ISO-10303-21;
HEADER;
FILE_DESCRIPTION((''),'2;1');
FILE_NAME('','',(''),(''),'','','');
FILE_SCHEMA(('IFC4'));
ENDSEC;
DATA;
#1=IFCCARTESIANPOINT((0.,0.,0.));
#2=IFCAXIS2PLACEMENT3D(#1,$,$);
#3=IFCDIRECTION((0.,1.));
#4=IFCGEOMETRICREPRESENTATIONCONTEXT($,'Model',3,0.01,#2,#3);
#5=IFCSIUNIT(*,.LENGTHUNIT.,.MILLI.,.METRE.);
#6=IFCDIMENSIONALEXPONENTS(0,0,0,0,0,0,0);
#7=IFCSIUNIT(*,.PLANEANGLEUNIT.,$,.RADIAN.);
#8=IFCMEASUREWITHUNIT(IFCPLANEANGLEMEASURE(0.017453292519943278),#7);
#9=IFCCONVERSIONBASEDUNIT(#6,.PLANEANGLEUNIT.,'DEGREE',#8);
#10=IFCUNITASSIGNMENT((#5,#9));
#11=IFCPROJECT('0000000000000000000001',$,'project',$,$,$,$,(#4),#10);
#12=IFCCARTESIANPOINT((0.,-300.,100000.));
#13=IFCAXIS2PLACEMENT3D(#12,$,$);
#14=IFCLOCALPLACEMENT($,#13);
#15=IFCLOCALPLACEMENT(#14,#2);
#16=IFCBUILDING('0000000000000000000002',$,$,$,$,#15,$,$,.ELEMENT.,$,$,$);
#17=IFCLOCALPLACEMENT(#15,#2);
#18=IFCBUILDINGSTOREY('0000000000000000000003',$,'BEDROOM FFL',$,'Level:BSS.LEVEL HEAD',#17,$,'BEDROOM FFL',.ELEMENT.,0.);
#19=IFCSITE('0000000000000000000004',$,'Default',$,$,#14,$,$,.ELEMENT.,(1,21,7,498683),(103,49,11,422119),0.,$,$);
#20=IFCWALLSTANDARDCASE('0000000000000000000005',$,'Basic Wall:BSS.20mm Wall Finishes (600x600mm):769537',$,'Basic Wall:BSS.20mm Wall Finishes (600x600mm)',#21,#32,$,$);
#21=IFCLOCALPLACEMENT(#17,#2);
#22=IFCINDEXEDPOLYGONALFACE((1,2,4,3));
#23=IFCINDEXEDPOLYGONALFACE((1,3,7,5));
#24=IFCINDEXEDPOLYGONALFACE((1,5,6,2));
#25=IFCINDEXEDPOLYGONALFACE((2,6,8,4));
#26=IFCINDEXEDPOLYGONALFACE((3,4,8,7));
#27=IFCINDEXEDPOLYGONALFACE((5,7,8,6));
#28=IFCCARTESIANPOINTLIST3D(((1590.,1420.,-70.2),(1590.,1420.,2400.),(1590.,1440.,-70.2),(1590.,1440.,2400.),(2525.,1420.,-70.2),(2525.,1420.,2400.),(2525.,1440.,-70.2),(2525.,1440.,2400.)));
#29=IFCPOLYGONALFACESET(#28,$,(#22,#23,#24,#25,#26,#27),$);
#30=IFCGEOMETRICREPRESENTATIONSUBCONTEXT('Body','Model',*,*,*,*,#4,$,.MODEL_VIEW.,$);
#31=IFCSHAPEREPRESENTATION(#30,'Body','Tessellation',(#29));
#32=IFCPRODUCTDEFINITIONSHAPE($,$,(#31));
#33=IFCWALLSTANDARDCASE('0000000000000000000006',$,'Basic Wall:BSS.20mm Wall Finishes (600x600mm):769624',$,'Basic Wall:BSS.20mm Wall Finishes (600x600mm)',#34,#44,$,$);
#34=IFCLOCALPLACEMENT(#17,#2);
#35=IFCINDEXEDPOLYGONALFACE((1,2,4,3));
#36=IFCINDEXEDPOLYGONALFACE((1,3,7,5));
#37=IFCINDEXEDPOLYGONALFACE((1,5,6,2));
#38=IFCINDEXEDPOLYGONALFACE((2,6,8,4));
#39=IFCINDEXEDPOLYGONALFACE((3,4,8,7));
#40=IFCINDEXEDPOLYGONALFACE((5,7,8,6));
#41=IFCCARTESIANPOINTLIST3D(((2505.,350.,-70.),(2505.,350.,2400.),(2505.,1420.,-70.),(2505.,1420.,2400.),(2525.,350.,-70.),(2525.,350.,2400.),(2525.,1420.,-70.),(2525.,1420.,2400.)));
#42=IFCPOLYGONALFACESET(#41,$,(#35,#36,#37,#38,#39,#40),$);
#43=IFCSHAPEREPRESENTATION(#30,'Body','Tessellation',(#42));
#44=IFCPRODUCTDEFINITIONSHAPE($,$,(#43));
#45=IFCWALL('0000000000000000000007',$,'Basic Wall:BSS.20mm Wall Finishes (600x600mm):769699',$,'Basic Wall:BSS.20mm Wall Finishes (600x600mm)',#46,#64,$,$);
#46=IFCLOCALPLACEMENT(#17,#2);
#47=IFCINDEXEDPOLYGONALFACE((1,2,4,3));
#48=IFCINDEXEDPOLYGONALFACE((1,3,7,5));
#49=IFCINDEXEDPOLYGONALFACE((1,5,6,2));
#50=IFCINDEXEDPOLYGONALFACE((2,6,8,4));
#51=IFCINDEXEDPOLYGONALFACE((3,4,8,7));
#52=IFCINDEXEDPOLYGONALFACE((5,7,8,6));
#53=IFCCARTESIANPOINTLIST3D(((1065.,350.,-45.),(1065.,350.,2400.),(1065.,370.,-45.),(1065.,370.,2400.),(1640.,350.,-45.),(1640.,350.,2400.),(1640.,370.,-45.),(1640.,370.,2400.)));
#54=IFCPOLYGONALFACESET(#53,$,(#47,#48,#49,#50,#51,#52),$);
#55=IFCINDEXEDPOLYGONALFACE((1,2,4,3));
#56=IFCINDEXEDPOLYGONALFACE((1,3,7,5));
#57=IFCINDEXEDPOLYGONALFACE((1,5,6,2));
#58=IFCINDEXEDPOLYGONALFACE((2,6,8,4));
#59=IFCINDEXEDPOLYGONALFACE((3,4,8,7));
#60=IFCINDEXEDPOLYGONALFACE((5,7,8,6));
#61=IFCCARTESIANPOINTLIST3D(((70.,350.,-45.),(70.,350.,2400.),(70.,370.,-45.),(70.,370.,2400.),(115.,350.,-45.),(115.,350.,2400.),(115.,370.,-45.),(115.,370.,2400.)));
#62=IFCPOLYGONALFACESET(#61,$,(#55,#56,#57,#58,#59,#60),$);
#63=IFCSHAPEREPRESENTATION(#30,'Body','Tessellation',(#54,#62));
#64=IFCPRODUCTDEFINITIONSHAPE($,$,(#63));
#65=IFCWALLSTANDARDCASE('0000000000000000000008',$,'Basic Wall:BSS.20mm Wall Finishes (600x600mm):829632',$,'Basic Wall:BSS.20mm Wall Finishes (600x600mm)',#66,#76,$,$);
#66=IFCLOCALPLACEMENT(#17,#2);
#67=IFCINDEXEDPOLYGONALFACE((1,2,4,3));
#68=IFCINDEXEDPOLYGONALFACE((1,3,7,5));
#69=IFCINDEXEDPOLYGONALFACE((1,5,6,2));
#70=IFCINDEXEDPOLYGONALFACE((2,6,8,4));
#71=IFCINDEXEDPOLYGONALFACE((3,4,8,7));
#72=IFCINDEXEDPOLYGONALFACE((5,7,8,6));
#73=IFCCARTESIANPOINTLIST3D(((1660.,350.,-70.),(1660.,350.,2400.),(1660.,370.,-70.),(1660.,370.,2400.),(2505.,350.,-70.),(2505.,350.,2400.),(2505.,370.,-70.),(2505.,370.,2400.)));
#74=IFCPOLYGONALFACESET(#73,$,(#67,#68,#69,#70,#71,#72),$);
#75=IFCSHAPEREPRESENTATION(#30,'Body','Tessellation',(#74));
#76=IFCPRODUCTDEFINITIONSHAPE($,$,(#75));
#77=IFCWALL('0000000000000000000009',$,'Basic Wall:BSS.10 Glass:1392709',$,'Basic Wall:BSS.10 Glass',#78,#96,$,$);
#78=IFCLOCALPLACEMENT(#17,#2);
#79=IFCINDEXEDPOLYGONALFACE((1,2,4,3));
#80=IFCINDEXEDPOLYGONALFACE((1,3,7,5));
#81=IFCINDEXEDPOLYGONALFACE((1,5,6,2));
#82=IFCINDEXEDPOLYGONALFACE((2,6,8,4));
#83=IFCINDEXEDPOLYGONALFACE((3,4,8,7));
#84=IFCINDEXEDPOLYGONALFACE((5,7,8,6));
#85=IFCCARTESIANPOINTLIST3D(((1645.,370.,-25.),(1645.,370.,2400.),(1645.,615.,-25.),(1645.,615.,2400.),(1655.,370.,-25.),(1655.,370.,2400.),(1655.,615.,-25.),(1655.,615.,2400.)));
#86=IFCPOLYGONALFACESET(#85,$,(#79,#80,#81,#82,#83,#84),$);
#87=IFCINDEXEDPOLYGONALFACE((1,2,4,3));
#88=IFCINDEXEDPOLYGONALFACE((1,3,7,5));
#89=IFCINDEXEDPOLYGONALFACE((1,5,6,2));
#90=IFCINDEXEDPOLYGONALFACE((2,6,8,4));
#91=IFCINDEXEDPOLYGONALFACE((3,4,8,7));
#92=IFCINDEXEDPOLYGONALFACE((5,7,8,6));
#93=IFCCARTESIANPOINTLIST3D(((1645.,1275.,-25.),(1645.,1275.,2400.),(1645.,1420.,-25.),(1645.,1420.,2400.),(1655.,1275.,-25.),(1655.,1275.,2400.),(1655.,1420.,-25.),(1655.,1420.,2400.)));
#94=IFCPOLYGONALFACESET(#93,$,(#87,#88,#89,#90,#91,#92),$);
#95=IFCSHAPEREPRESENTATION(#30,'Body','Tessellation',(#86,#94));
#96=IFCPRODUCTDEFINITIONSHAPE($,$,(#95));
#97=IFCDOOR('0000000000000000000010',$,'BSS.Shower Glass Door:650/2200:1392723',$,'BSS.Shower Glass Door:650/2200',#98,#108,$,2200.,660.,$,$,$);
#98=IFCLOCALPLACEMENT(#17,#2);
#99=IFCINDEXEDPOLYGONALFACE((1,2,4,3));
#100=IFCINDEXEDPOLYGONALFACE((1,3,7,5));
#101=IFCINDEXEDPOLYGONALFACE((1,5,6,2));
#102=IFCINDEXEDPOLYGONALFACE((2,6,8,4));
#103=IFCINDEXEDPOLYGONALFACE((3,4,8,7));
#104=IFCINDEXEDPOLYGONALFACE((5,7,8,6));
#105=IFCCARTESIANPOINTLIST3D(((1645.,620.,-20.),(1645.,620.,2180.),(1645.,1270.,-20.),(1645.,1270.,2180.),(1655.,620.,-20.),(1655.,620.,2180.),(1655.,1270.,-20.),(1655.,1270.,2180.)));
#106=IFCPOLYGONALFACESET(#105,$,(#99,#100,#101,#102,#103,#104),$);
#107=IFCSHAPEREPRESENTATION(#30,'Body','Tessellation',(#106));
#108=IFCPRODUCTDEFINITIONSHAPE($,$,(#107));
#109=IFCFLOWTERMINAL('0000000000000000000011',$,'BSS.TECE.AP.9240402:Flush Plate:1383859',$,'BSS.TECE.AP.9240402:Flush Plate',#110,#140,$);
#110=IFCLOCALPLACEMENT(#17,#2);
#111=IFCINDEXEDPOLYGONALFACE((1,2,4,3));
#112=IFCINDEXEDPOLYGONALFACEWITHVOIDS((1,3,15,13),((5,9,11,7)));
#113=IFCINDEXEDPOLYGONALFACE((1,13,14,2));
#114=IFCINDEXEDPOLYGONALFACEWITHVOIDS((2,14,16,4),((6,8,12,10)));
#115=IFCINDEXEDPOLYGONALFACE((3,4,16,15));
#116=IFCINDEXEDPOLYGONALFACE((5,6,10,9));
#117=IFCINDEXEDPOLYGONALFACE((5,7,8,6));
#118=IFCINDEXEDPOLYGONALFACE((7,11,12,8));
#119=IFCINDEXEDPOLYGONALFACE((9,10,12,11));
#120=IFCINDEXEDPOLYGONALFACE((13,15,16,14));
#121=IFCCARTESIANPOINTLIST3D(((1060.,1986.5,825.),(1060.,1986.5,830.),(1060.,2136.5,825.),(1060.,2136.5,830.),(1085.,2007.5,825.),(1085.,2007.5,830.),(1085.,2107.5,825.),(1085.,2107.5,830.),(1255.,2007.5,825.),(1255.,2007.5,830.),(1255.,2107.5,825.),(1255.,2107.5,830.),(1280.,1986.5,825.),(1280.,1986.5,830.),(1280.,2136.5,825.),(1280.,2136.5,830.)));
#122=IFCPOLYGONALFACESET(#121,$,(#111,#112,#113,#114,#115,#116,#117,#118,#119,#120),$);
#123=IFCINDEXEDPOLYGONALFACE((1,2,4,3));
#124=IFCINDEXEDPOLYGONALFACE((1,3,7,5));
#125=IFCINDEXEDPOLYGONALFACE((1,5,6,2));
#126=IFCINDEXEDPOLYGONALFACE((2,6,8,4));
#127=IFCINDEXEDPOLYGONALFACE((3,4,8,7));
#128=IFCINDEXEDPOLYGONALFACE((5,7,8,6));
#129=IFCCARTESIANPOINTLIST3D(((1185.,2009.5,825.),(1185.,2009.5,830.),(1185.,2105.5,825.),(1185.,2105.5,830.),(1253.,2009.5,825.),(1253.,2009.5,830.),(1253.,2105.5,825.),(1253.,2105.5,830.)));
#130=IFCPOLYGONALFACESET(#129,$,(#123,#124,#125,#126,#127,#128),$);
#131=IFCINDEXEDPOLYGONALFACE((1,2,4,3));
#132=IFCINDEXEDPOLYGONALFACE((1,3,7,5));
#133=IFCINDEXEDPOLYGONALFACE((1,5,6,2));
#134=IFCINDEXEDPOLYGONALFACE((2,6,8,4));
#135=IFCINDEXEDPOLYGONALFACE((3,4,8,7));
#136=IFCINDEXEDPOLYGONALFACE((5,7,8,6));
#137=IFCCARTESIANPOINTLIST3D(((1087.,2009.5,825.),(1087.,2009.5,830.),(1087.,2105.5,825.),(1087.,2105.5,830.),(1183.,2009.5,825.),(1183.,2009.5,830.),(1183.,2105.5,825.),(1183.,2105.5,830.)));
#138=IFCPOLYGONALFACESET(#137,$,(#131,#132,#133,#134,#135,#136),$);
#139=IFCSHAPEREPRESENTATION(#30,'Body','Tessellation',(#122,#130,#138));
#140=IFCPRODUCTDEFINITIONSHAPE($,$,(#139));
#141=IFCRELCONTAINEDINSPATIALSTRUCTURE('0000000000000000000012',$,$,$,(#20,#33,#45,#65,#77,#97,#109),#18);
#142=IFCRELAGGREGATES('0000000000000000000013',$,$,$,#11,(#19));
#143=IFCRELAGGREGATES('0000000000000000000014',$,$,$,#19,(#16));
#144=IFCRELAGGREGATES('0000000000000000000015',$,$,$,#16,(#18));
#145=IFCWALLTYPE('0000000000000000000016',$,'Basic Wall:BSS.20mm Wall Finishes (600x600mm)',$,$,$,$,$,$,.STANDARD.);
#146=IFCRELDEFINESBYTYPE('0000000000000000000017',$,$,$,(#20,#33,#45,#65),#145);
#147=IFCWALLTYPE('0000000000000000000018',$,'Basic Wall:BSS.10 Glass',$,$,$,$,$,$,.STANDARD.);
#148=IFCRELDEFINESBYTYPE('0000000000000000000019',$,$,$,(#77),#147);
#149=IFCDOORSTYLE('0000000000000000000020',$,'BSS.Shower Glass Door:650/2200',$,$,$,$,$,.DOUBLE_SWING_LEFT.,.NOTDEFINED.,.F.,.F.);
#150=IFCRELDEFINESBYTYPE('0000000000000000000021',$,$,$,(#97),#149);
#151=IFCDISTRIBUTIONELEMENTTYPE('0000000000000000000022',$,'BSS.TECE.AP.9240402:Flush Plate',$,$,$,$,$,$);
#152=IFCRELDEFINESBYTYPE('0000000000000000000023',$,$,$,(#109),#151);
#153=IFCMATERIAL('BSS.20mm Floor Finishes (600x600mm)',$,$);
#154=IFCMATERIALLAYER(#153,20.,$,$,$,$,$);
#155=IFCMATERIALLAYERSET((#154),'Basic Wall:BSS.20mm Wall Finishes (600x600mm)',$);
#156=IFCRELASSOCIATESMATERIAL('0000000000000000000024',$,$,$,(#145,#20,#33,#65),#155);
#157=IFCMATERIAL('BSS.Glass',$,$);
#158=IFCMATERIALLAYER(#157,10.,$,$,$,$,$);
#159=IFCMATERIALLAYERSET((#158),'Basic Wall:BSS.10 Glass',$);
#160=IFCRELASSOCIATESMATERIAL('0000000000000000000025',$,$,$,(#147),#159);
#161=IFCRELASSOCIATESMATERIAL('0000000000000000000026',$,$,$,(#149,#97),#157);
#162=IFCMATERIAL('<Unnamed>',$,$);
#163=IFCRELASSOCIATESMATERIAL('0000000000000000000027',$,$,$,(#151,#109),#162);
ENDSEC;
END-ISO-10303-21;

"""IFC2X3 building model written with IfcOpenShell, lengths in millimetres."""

from ifc_helpers import new_model, entity, si_unit, converted_unit, direction, frame, frame_2d, origin, origin_2d_with_axis, place, context, subcontext, project, spatial, polyline, rectangle, outline, extrude, source, transform, mapped, material, layer, layer_set, layer_usage, type_object, type_shapes, element, fill, save


model = new_model("IFC2X3")

# Units and contexts
model_context = context("Model", 3, precision=0.01, world=origin(), true_north=direction((0.0, 1.0)))
body_context = subcontext(model_context, "Body", "Model", "MODEL_VIEW")
ifc_project = project(units=[si_unit("LENGTHUNIT", "METRE", prefix="MILLI"), converted_unit("PLANEANGLEUNIT", "DEGREE", entity("IfcPlaneAngleMeasure", 0.017453292519943278), si_unit("PLANEANGLEUNIT", "RADIAN"), dimensions=[0, 0, 0, 0, 0, 0, 0])], contexts=[model_context])

# Site, building, storey
site_placement = place(None, frame((0.0, -300.0, 100000.0)))
site = spatial("IfcSite", under=ifc_project, at=site_placement, Name="Default", CompositionType="ELEMENT", RefLatitude=(1, 21, 7, 498683), RefLongitude=(103, 49, 11, 422119), RefElevation=0.0)
building_placement = place(site_placement, origin())
building = spatial("IfcBuilding", under=site, at=building_placement, CompositionType="ELEMENT")
storey_placement = place(building_placement, origin())
storey = spatial("IfcBuildingStorey", under=building, at=storey_placement, Name="BEDROOM FFL", ObjectType="Level:BSS.LEVEL HEAD", LongName="BEDROOM FFL", CompositionType="ELEMENT", Elevation=0.0)

# Shared definitions
ifc_material_1 = material(Name="BSS.20mm Floor Finishes (600x600mm)")

# Shared definitions
ifc_layer_1 = layer(ifc_material_1, 20.0)
ifc_layer_set_1 = layer_set([ifc_layer_1], Name="Basic Wall:BSS.20mm Wall Finishes (600x600mm)")
wall_type_1 = type_object("IfcWallType", Name="Basic Wall:BSS.20mm Wall Finishes (600x600mm)", PredefinedType="STANDARD", material=ifc_layer_set_1)

# Walls
ifc_layer_usage_1 = layer_usage(ifc_layer_set_1, "AXIS2", "NEGATIVE", 10.0)
wall_1_placement = place(storey_placement, frame((1590.0, 1430.0, -70.2)))
element("IfcWallStandardCase", 1, at=wall_1_placement, inside=storey, type_object=wall_type_1, material=ifc_layer_usage_1, Name="Basic Wall:BSS.20mm Wall Finishes (600x600mm):769537", ObjectType="Basic Wall:BSS.20mm Wall Finishes (600x600mm)", context=body_context, shape_type="SweptSolid", body=[
    extrude(rectangle(XDim=935.0, YDim=20.0, at=frame_2d((467.5, 0.0), x_axis=(-1.0, 0.0))), origin(), (0.0, 0.0, 1.0), 2470.2),
])
ifc_layer_usage_2 = layer_usage(ifc_layer_set_1, "AXIS2", "NEGATIVE", 10.0)
wall_2_placement = place(storey_placement, frame((2515.0, 1420.0, -70.0), z_axis=(0.0, 0.0, 1.0), x_axis=(0.0, -1.0, 0.0)))
element("IfcWallStandardCase", 2, at=wall_2_placement, inside=storey, type_object=wall_type_1, material=ifc_layer_usage_2, Name="Basic Wall:BSS.20mm Wall Finishes (600x600mm):769624", ObjectType="Basic Wall:BSS.20mm Wall Finishes (600x600mm)", context=body_context, shape_type="SweptSolid", body=[
    extrude(rectangle(XDim=1070.0, YDim=20.0, at=frame_2d((535.0, 0.0), x_axis=(-1.0, 0.0))), origin(), (0.0, 0.0, 1.0), 2470.0),
])
wall_3_placement = place(storey_placement, frame((1640.0, 360.0, -45.0), z_axis=(0.0, 0.0, 1.0), x_axis=(-1.0, 0.0, 0.0)))
element("IfcWall", 3, at=wall_3_placement, inside=storey, type_object=wall_type_1, Name="Basic Wall:BSS.20mm Wall Finishes (600x600mm):769699", ObjectType="Basic Wall:BSS.20mm Wall Finishes (600x600mm)", context=body_context, shape_type="SweptSolid", body=[
    extrude(rectangle(XDim=575.0, YDim=20.0, at=frame_2d((0.0, 0.0), x_axis=(1.0, 0.0))), frame((287.5, 0.0, 0.0)), (0.0, 0.0, 1.0), 2445.0),
    extrude(rectangle(XDim=45.0, YDim=20.0, at=frame_2d((0.0, 0.0), x_axis=(1.0, 0.0))), frame((1547.5, 0.0, 0.0), z_axis=(0.0, 0.0, 1.0), x_axis=(-1.0, 0.0, 0.0)), (0.0, 0.0, 1.0), 2445.0),
])
ifc_layer_usage_3 = layer_usage(ifc_layer_set_1, "AXIS2", "NEGATIVE", 10.0)
wall_4_placement = place(storey_placement, frame((1660.0, 360.0, -70.0)))
element("IfcWallStandardCase", 4, at=wall_4_placement, inside=storey, type_object=wall_type_1, material=ifc_layer_usage_3, Name="Basic Wall:BSS.20mm Wall Finishes (600x600mm):829632", ObjectType="Basic Wall:BSS.20mm Wall Finishes (600x600mm)", context=body_context, shape_type="SweptSolid", body=[
    extrude(rectangle(XDim=845.0, YDim=20.0, at=frame_2d((422.5, 0.0), x_axis=(-1.0, 0.0))), origin(), (0.0, 0.0, 1.0), 2470.0),
])

# Wall, opening, door
ifc_material_2 = material(Name="BSS.Glass")
ifc_layer_2 = layer(ifc_material_2, 10.0)
ifc_layer_set_2 = layer_set([ifc_layer_2], Name="Basic Wall:BSS.10 Glass")
wall_type_2 = type_object("IfcWallType", Name="Basic Wall:BSS.10 Glass", PredefinedType="STANDARD", material=ifc_layer_set_2)
wall_5_placement = place(storey_placement, frame((1650.0, 370.0, -25.0), z_axis=(0.0, 0.0, 1.0), x_axis=(0.0, 1.0, 0.0)))
wall_5 = element("IfcWall", 5, at=wall_5_placement, inside=storey, type_object=wall_type_2, Name="Basic Wall:BSS.10 Glass:1392709", ObjectType="Basic Wall:BSS.10 Glass", context=body_context, shape_type="SweptSolid", body=[
    extrude(rectangle(XDim=245.0, YDim=10.0, at=frame_2d((0.0, 0.0), x_axis=(1.0, 0.0))), frame((122.5, 0.0, 0.0)), (0.0, 0.0, 1.0), 2425.0),
    extrude(rectangle(XDim=145.0, YDim=10.0, at=frame_2d((0.0, 0.0), x_axis=(1.0, 0.0))), frame((977.5, 0.0, 0.0), z_axis=(0.0, 0.0, 1.0), x_axis=(-1.0, 0.0, 0.0)), (0.0, 0.0, 1.0), 2425.0),
])
opening_1_placement = place(wall_5_placement, frame((245.0, -5.0, 5.0)))
opening_1 = element("IfcOpeningElement", 6, at=opening_1_placement, cuts=wall_5, ObjectType="Opening", context=body_context, shape_type="SweptSolid", body=[
    extrude(rectangle(XDim=660.0, YDim=2200.0, at=frame_2d((1100.0, 330.0), x_axis=(0.0, -1.0))), frame((0.0, 0.0, 0.0), z_axis=(0.0, 1.0, 0.0), x_axis=(0.0, 0.0, 1.0)), (0.0, 0.0, 1.0), 10.0),
])
door_style = type_object("IfcDoorStyle", Name="BSS.Shower Glass Door:650/2200", ConstructionType="NOTDEFINED", OperationType="DOUBLE_SWING_LEFT", ParameterTakesPrecedence=False, Sizeable=False, material=ifc_material_2)
shared_shape_1 = source(origin(), body_context, "Body", "SweptSolid", [
    extrude(rectangle(XDim=10.0, YDim=650.0, at=origin_2d_with_axis()), frame((330.0, 5.0, 0.0), z_axis=(0.0, 0.0, 1.0), x_axis=(0.0, -1.0, 0.0)), (0.0, 0.0, 1.0), 2200.0),
])
type_shapes(door_style, [shared_shape_1])
door_placement = place(opening_1_placement, origin())
door = element("IfcDoor", 7, at=door_placement, inside=storey, type_object=door_style, material=ifc_material_2, Name="BSS.Shower Glass Door:650/2200:1392723", ObjectType="BSS.Shower Glass Door:650/2200", OverallHeight=2200.0, OverallWidth=660.0, context=body_context, shape_type="MappedRepresentation", body=[
    mapped(shared_shape_1, transform((0.0, 0.0, 0.0), scale=1.0)),
])
fill(opening_1, door)

# Flow terminal
ifc_material_3 = material(Name="<Unnamed>")
distribution_element_type = type_object("IfcDistributionElementType", Name="BSS.TECE.AP.9240402:Flush Plate", material=ifc_material_3)
shared_shape_2 = source(origin(), body_context, "Body", "SweptSolid", [
    extrude(outline(polyline([(-110.0, -75.0), (110.0, -75.0), (110.0, 75.0), (-110.0, 75.0), (-110.0, -75.0)]), holes=[polyline([(-85.0, -46.0), (-85.0, 54.0), (85.0, 54.0), (85.0, -46.0), (-85.0, -46.0)])]), frame((0.0, 0.0, 0.0), z_axis=(0.0, 0.0, 1.0), x_axis=(-1.0, 0.0, 0.0)), (0.0, 0.0, 1.0), 5.0),
    extrude(rectangle(XDim=68.0, YDim=96.0, at=frame_2d((0.0, 0.0), x_axis=(1.0, 0.0))), frame((49.0, -4.0, 0.0)), (0.0, 0.0, 1.0), 5.0),
    extrude(rectangle(XDim=96.0, YDim=96.0, at=frame_2d((0.0, 0.0), x_axis=(1.0, 0.0))), frame((-35.0, -4.0, 0.0)), (0.0, 0.0, 1.0), 5.0),
])
type_shapes(distribution_element_type, [shared_shape_2])
flow_terminal_placement = place(storey_placement, frame((1170.0, 2061.5, 825.0)))
element("IfcFlowTerminal", 8, at=flow_terminal_placement, inside=storey, type_object=distribution_element_type, material=ifc_material_3, Name="BSS.TECE.AP.9240402:Flush Plate:1383859", ObjectType="BSS.TECE.AP.9240402:Flush Plate", context=body_context, shape_type="MappedRepresentation", body=[
    mapped(shared_shape_2, transform((0.0, 0.0, 0.0), scale=1.0)),
])

save(model, "model.ifc")
